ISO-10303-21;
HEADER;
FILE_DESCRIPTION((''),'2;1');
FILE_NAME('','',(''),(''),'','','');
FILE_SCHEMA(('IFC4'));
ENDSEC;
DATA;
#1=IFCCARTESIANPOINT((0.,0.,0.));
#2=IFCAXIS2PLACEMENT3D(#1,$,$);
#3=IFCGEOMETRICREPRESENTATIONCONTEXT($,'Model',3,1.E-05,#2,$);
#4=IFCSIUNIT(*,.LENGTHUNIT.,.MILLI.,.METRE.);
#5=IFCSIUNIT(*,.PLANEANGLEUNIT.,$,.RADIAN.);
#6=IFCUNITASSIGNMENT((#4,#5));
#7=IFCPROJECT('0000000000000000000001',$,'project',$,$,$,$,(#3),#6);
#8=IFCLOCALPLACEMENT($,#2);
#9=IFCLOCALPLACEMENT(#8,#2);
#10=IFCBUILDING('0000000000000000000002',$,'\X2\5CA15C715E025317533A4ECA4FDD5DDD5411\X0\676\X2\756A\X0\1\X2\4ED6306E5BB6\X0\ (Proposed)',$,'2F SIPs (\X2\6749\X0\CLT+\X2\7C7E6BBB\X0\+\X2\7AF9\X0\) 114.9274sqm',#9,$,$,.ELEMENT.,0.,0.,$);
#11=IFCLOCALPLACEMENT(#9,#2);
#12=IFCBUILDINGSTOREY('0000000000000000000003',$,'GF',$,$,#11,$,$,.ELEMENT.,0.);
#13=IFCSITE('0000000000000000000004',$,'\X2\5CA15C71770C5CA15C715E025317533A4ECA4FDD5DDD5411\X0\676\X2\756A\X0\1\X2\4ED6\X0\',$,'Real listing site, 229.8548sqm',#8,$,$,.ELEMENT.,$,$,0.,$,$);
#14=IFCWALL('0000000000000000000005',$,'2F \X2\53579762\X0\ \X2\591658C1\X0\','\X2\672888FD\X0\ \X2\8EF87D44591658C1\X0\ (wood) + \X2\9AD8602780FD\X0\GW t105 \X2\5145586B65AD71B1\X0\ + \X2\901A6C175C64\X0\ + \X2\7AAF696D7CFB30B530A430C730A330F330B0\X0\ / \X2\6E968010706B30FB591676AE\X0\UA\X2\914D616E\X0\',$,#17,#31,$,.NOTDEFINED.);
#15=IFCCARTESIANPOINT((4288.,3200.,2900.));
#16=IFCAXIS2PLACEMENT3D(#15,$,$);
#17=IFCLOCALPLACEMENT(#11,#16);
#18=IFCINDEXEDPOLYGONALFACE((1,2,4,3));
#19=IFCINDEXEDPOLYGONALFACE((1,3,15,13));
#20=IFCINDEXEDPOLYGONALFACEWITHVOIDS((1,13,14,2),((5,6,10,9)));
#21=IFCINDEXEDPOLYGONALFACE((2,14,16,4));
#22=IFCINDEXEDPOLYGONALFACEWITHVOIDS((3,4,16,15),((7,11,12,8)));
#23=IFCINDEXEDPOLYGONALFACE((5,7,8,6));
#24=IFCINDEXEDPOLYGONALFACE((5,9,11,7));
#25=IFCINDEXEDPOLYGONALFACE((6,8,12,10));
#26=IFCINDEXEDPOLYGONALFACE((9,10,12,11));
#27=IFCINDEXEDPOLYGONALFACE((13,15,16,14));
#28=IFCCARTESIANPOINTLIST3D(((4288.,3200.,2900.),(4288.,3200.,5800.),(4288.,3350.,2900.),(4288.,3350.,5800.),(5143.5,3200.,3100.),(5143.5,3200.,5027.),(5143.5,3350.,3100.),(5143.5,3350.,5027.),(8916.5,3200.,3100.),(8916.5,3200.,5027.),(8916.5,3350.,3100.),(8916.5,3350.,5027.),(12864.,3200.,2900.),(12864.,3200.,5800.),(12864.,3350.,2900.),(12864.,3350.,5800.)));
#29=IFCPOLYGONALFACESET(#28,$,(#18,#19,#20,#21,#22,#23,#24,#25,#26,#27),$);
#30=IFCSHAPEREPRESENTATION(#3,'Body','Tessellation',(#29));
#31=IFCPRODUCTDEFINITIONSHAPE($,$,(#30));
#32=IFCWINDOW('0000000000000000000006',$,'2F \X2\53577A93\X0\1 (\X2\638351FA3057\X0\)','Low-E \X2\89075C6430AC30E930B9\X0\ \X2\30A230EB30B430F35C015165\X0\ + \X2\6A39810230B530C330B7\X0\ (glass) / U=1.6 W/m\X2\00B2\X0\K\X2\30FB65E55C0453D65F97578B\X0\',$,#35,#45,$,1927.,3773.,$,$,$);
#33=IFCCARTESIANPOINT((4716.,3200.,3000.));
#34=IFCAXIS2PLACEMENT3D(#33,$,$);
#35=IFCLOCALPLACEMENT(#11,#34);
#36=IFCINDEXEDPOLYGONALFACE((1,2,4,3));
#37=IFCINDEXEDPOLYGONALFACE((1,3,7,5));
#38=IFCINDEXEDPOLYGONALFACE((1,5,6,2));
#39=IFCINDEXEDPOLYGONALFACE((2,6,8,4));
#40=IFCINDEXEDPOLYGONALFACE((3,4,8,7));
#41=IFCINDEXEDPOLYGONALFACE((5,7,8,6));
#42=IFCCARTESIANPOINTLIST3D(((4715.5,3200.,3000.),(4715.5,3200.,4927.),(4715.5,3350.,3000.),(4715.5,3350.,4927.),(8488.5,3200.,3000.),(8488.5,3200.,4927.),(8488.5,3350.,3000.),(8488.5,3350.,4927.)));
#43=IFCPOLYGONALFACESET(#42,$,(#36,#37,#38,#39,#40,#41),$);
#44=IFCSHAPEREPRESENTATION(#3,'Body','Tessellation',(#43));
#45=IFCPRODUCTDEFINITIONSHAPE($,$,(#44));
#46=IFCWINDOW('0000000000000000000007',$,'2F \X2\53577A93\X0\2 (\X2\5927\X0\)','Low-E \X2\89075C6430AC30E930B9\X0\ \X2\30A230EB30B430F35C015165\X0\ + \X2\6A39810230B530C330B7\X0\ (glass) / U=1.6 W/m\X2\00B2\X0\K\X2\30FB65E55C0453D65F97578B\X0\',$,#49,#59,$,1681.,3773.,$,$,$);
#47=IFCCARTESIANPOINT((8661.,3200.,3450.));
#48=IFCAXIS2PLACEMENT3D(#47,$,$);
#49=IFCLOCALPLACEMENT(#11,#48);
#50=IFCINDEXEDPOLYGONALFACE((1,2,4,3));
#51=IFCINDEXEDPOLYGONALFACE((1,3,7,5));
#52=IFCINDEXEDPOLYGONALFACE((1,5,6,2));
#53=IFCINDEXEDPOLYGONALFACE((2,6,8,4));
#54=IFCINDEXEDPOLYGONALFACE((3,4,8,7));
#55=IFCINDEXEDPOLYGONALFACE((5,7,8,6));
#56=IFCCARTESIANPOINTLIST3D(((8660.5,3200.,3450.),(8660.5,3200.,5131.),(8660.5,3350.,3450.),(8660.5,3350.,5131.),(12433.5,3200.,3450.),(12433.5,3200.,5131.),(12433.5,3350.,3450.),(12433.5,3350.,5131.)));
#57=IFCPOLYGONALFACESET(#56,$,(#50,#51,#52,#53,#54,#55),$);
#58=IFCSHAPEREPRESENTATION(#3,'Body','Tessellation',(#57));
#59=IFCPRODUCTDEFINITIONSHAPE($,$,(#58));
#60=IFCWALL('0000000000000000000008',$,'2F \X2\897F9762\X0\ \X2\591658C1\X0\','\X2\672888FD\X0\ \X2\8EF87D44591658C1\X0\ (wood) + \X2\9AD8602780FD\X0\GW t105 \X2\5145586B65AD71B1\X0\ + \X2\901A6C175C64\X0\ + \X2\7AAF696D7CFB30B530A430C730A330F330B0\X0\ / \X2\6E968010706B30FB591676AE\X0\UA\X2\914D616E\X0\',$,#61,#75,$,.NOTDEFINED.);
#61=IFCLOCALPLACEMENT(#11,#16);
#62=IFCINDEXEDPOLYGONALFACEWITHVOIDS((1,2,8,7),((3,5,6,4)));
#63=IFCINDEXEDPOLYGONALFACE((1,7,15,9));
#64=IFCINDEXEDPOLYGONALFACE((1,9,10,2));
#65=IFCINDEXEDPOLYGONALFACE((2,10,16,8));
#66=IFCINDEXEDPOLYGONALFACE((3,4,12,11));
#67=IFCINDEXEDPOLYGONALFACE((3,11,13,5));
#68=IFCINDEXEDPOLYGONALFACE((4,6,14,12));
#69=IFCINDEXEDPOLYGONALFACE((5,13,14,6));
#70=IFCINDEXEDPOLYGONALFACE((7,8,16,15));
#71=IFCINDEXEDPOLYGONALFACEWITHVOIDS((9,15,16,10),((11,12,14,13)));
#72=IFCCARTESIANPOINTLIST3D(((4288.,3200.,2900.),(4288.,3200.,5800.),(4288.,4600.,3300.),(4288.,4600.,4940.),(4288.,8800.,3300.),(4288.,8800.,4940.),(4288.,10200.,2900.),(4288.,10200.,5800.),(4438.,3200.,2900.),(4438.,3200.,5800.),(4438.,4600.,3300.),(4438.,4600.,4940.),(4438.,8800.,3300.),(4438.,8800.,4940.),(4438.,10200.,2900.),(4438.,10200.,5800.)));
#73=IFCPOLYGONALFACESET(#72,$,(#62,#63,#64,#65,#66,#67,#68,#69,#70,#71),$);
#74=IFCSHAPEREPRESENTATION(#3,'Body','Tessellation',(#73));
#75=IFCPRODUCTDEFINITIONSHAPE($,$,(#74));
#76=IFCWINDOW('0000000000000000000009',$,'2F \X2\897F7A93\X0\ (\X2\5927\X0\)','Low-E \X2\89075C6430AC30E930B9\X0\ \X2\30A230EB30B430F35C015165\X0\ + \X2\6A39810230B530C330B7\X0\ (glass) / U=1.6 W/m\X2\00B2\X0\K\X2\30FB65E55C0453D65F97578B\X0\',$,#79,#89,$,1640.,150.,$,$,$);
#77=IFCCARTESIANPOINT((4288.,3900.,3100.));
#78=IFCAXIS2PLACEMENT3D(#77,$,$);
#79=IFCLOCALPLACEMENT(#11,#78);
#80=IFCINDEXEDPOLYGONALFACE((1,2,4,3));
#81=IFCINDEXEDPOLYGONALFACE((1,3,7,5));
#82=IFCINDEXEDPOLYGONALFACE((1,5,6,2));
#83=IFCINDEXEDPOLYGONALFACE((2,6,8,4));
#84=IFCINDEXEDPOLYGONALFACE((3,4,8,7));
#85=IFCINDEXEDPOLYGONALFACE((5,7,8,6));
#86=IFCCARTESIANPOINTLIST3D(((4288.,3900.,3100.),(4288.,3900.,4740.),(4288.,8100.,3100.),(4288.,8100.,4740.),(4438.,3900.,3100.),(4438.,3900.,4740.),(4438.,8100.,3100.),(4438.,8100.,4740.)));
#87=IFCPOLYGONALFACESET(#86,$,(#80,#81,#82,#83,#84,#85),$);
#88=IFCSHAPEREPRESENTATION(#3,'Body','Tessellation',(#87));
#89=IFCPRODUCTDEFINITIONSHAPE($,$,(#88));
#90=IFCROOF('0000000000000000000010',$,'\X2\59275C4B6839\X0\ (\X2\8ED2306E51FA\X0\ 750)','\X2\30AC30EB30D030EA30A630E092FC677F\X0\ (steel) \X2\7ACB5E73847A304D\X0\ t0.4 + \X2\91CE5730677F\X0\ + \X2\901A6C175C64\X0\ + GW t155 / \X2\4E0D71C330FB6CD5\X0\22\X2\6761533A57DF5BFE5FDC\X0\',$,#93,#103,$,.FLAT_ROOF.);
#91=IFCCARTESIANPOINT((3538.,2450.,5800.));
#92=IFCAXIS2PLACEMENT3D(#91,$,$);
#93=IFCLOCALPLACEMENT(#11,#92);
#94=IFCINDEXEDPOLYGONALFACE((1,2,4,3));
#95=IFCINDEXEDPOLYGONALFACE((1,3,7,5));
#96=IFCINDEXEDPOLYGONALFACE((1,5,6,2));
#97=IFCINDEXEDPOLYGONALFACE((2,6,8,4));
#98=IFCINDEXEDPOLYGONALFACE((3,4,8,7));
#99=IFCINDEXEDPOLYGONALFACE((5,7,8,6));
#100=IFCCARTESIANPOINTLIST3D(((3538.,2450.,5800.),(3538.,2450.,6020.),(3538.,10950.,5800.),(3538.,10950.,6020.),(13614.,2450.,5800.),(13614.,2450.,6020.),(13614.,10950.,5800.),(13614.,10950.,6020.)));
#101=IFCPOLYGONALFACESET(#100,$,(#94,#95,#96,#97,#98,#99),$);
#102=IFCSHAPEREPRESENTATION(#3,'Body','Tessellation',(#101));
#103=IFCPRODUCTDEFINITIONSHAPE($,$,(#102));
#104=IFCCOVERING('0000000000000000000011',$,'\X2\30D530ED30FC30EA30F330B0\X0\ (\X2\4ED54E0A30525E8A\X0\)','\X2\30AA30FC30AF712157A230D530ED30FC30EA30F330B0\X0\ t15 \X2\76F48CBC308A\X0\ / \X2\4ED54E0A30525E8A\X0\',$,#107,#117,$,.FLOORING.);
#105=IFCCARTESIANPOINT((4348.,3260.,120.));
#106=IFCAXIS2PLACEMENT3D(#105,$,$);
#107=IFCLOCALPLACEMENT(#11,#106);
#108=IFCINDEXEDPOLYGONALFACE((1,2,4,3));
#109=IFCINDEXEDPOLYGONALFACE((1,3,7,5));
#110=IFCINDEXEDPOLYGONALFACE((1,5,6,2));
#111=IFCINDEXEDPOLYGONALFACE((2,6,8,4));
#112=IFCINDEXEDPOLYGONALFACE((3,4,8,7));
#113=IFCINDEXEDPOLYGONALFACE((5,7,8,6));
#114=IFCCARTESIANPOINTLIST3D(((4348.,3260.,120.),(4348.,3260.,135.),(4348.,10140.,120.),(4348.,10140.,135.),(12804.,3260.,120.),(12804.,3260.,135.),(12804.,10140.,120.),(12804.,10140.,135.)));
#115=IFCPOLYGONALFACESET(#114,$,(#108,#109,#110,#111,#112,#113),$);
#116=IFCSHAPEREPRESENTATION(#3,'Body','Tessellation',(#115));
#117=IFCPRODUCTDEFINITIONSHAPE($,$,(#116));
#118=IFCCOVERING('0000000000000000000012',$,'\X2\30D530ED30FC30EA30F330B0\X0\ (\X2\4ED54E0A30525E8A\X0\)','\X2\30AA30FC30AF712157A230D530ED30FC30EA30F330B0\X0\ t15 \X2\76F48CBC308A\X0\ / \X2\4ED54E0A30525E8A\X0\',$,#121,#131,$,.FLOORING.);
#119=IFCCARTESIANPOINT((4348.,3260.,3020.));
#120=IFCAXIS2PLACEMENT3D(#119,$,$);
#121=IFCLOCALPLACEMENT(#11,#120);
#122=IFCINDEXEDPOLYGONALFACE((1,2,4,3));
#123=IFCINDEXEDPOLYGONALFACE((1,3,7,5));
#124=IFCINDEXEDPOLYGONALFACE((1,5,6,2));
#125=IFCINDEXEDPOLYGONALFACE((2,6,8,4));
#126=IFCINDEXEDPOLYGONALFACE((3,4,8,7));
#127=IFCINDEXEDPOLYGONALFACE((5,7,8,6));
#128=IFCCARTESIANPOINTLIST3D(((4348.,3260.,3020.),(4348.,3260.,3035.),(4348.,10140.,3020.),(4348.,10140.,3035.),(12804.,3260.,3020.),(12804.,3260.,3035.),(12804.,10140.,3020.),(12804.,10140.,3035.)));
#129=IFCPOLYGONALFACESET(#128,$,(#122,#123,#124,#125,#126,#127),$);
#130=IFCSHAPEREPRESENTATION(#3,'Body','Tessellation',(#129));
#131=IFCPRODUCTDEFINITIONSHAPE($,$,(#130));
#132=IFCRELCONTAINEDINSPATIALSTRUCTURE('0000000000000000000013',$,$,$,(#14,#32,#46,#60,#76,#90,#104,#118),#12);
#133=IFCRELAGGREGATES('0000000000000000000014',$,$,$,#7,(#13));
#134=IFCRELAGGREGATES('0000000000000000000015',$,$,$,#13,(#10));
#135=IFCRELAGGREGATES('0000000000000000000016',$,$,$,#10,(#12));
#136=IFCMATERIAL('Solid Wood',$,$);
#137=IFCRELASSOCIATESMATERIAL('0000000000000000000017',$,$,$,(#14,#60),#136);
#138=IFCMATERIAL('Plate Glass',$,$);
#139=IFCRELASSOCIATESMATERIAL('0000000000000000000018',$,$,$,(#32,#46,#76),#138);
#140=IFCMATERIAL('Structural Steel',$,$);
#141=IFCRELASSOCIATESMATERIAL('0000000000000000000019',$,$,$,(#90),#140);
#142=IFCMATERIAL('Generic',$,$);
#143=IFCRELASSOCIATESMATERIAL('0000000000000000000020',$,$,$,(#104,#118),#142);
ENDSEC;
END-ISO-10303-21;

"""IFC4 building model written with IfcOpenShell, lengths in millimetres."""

from ifc_helpers import new_model, si_unit, frame, frame_2d, origin, place, context, project, spatial, rectangle, extrude, material, element, fill, save


model = new_model("IFC4")

# Units and contexts
model_context = context("Model", 3, precision=1e-05, world=origin())
ifc_project = project(units=[si_unit("LENGTHUNIT", "METRE", prefix="MILLI"), si_unit("PLANEANGLEUNIT", "RADIAN")], contexts=[model_context])

# Site, building, storey
site_placement = place(None, origin())
site = spatial("IfcSite", under=ifc_project, at=site_placement, Name="岡山県岡山市北区今保川向676番1他", ObjectType="Real listing site, 229.8548sqm", CompositionType="ELEMENT", RefElevation=0.0)
building_placement = place(site_placement, origin())
building = spatial("IfcBuilding", under=site, at=building_placement, Name="岡山市北区今保川向676番1他の家 (Proposed)", ObjectType="2F SIPs (杉CLT+籾殻+竹) 114.9274sqm", CompositionType="ELEMENT", ElevationOfRefHeight=0.0, ElevationOfTerrain=0.0)
storey_placement = place(building_placement, origin())
storey = spatial("IfcBuildingStorey", under=building, at=storey_placement, Name="GF", CompositionType="ELEMENT", Elevation=0.0)

# Shared definitions
ifc_material_1 = material(Name="Solid Wood")

# Shared definitions
ifc_material_2 = material(Name="Plate Glass")

# Wall, openings, windows
wall_1_placement = place(storey_placement, frame((4288.0, 3200.0, 2900.0)))
wall_1 = element("IfcWall", 1, at=wall_1_placement, inside=storey, material=ifc_material_1, Name="2F 南面 外壁", Description="木製 軸組外壁 (wood) + 高性能GW t105 充填断熱 + 通気層 + 窯業系サイディング / 準耐火・外皮UA配慮", PredefinedType="NOTDEFINED", context=model_context, shape_type="SweptSolid", body=[
    extrude(rectangle(XDim=8576.0, YDim=150.0, at=frame_2d((4288.0, 75.0))), frame((4288.0, 3200.0, 2900.0)), (0.0, 0.0, 1.0), 2900.0),
])
opening_1_placement = place(storey_placement, frame((4716.0, 3200.0, 3000.0)))
opening_1 = element("IfcOpeningElement", 2, at=opening_1_placement, cuts=wall_1, PredefinedType="NOTDEFINED", context=model_context, shape_type="SweptSolid", body=[
    extrude(rectangle(XDim=3773.0, YDim=150.0, at=frame_2d((1886.0, 75.0))), frame((4716.0, 3200.0, 3000.0)), (0.0, 0.0, 1.0), 1927.0),
])
opening_2_placement = place(storey_placement, frame((8661.0, 3200.0, 3450.0)))
opening_2 = element("IfcOpeningElement", 3, at=opening_2_placement, cuts=wall_1, PredefinedType="NOTDEFINED", context=model_context, shape_type="SweptSolid", body=[
    extrude(rectangle(XDim=3773.0, YDim=150.0, at=frame_2d((1886.0, 75.0))), frame((8661.0, 3200.0, 3450.0)), (0.0, 0.0, 1.0), 1681.0),
])
window_1_placement = place(storey_placement, frame((4716.0, 3200.0, 3000.0)))
window_1 = element("IfcWindow", 4, at=window_1_placement, inside=storey, material=ifc_material_2, Name="2F 南窓1 (掃出し)", Description="Low-E 複層ガラス アルゴン封入 + 樹脂サッシ (glass) / U=1.6 W/m²K・日射取得型", OverallHeight=1927.0, OverallWidth=3773.0, context=model_context, shape_type="SweptSolid", body=[
    extrude(rectangle(XDim=3773.0, YDim=150.0, at=frame_2d((1886.0, 75.0))), frame((4716.0, 3200.0, 3000.0)), (0.0, 0.0, 1.0), 1927.0),
])
fill(opening_1, window_1)
window_2_placement = place(storey_placement, frame((8661.0, 3200.0, 3450.0)))
window_2 = element("IfcWindow", 5, at=window_2_placement, inside=storey, material=ifc_material_2, Name="2F 南窓2 (大)", Description="Low-E 複層ガラス アルゴン封入 + 樹脂サッシ (glass) / U=1.6 W/m²K・日射取得型", OverallHeight=1681.0, OverallWidth=3773.0, context=model_context, shape_type="SweptSolid", body=[
    extrude(rectangle(XDim=3773.0, YDim=150.0, at=frame_2d((1886.0, 75.0))), frame((8661.0, 3200.0, 3450.0)), (0.0, 0.0, 1.0), 1681.0),
])
fill(opening_2, window_2)

# Wall, opening, window
wall_2_placement = place(storey_placement, frame((4288.0, 3200.0, 2900.0)))
wall_2 = element("IfcWall", 6, at=wall_2_placement, inside=storey, material=ifc_material_1, Name="2F 西面 外壁", Description="木製 軸組外壁 (wood) + 高性能GW t105 充填断熱 + 通気層 + 窯業系サイディング / 準耐火・外皮UA配慮", PredefinedType="NOTDEFINED", context=model_context, shape_type="SweptSolid", body=[
    extrude(rectangle(XDim=150.0, YDim=7000.0, at=frame_2d((75.0, 3500.0))), frame((4288.0, 3200.0, 2900.0)), (0.0, 0.0, 1.0), 2900.0),
])
opening_3_placement = place(storey_placement, frame((4288.0, 3900.0, 3100.0)))
opening_3 = element("IfcOpeningElement", 7, at=opening_3_placement, cuts=wall_2, PredefinedType="NOTDEFINED", context=model_context, shape_type="SweptSolid", body=[
    extrude(rectangle(XDim=150.0, YDim=4200.0, at=frame_2d((75.0, 2100.0))), frame((4288.0, 3900.0, 3100.0)), (0.0, 0.0, 1.0), 1640.0),
])
window_3_placement = place(storey_placement, frame((4288.0, 3900.0, 3100.0)))
window_3 = element("IfcWindow", 8, at=window_3_placement, inside=storey, material=ifc_material_2, Name="2F 西窓 (大)", Description="Low-E 複層ガラス アルゴン封入 + 樹脂サッシ (glass) / U=1.6 W/m²K・日射取得型", OverallHeight=1640.0, OverallWidth=150.0, context=model_context, shape_type="SweptSolid", body=[
    extrude(rectangle(XDim=150.0, YDim=4200.0, at=frame_2d((75.0, 2100.0))), frame((4288.0, 3900.0, 3100.0)), (0.0, 0.0, 1.0), 1640.0),
])
fill(opening_3, window_3)

# Roof
ifc_material_3 = material(Name="Structural Steel")
roof_placement = place(storey_placement, frame((3538.0, 2450.0, 5800.0)))
element("IfcRoof", 9, at=roof_placement, inside=storey, material=ifc_material_3, Name="大屋根 (軒の出 750)", Description="ガルバリウム鋼板 (steel) 立平葺き t0.4 + 野地板 + 通気層 + GW t155 / 不燃・法22条区域対応", PredefinedType="FLAT_ROOF", context=model_context, shape_type="SweptSolid", body=[
    extrude(rectangle(XDim=10076.0, YDim=8500.0, at=frame_2d((5038.0, 4250.0))), frame((3538.0, 2450.0, 5800.0)), (0.0, 0.0, 1.0), 220.0),
])

# Coverings
ifc_material_4 = material(Name="Generic")
covering_1_placement = place(storey_placement, frame((4348.0, 3260.0, 120.0)))
element("IfcCovering", 10, at=covering_1_placement, inside=storey, material=ifc_material_4, Name="フローリング (仕上げ床)", Description="オーク無垢フローリング t15 直貼り / 仕上げ床", PredefinedType="FLOORING", context=model_context, shape_type="SweptSolid", body=[
    extrude(rectangle(XDim=8456.0, YDim=6880.0, at=frame_2d((4228.0, 3440.0))), frame((4348.0, 3260.0, 120.0)), (0.0, 0.0, 1.0), 15.0),
])
covering_2_placement = place(storey_placement, frame((4348.0, 3260.0, 3020.0)))
element("IfcCovering", 11, at=covering_2_placement, inside=storey, material=ifc_material_4, Name="フローリング (仕上げ床)", Description="オーク無垢フローリング t15 直貼り / 仕上げ床", PredefinedType="FLOORING", context=model_context, shape_type="SweptSolid", body=[
    extrude(rectangle(XDim=8456.0, YDim=6880.0, at=frame_2d((4228.0, 3440.0))), frame((4348.0, 3260.0, 3020.0)), (0.0, 0.0, 1.0), 15.0),
])

save(model, "model.ifc")
